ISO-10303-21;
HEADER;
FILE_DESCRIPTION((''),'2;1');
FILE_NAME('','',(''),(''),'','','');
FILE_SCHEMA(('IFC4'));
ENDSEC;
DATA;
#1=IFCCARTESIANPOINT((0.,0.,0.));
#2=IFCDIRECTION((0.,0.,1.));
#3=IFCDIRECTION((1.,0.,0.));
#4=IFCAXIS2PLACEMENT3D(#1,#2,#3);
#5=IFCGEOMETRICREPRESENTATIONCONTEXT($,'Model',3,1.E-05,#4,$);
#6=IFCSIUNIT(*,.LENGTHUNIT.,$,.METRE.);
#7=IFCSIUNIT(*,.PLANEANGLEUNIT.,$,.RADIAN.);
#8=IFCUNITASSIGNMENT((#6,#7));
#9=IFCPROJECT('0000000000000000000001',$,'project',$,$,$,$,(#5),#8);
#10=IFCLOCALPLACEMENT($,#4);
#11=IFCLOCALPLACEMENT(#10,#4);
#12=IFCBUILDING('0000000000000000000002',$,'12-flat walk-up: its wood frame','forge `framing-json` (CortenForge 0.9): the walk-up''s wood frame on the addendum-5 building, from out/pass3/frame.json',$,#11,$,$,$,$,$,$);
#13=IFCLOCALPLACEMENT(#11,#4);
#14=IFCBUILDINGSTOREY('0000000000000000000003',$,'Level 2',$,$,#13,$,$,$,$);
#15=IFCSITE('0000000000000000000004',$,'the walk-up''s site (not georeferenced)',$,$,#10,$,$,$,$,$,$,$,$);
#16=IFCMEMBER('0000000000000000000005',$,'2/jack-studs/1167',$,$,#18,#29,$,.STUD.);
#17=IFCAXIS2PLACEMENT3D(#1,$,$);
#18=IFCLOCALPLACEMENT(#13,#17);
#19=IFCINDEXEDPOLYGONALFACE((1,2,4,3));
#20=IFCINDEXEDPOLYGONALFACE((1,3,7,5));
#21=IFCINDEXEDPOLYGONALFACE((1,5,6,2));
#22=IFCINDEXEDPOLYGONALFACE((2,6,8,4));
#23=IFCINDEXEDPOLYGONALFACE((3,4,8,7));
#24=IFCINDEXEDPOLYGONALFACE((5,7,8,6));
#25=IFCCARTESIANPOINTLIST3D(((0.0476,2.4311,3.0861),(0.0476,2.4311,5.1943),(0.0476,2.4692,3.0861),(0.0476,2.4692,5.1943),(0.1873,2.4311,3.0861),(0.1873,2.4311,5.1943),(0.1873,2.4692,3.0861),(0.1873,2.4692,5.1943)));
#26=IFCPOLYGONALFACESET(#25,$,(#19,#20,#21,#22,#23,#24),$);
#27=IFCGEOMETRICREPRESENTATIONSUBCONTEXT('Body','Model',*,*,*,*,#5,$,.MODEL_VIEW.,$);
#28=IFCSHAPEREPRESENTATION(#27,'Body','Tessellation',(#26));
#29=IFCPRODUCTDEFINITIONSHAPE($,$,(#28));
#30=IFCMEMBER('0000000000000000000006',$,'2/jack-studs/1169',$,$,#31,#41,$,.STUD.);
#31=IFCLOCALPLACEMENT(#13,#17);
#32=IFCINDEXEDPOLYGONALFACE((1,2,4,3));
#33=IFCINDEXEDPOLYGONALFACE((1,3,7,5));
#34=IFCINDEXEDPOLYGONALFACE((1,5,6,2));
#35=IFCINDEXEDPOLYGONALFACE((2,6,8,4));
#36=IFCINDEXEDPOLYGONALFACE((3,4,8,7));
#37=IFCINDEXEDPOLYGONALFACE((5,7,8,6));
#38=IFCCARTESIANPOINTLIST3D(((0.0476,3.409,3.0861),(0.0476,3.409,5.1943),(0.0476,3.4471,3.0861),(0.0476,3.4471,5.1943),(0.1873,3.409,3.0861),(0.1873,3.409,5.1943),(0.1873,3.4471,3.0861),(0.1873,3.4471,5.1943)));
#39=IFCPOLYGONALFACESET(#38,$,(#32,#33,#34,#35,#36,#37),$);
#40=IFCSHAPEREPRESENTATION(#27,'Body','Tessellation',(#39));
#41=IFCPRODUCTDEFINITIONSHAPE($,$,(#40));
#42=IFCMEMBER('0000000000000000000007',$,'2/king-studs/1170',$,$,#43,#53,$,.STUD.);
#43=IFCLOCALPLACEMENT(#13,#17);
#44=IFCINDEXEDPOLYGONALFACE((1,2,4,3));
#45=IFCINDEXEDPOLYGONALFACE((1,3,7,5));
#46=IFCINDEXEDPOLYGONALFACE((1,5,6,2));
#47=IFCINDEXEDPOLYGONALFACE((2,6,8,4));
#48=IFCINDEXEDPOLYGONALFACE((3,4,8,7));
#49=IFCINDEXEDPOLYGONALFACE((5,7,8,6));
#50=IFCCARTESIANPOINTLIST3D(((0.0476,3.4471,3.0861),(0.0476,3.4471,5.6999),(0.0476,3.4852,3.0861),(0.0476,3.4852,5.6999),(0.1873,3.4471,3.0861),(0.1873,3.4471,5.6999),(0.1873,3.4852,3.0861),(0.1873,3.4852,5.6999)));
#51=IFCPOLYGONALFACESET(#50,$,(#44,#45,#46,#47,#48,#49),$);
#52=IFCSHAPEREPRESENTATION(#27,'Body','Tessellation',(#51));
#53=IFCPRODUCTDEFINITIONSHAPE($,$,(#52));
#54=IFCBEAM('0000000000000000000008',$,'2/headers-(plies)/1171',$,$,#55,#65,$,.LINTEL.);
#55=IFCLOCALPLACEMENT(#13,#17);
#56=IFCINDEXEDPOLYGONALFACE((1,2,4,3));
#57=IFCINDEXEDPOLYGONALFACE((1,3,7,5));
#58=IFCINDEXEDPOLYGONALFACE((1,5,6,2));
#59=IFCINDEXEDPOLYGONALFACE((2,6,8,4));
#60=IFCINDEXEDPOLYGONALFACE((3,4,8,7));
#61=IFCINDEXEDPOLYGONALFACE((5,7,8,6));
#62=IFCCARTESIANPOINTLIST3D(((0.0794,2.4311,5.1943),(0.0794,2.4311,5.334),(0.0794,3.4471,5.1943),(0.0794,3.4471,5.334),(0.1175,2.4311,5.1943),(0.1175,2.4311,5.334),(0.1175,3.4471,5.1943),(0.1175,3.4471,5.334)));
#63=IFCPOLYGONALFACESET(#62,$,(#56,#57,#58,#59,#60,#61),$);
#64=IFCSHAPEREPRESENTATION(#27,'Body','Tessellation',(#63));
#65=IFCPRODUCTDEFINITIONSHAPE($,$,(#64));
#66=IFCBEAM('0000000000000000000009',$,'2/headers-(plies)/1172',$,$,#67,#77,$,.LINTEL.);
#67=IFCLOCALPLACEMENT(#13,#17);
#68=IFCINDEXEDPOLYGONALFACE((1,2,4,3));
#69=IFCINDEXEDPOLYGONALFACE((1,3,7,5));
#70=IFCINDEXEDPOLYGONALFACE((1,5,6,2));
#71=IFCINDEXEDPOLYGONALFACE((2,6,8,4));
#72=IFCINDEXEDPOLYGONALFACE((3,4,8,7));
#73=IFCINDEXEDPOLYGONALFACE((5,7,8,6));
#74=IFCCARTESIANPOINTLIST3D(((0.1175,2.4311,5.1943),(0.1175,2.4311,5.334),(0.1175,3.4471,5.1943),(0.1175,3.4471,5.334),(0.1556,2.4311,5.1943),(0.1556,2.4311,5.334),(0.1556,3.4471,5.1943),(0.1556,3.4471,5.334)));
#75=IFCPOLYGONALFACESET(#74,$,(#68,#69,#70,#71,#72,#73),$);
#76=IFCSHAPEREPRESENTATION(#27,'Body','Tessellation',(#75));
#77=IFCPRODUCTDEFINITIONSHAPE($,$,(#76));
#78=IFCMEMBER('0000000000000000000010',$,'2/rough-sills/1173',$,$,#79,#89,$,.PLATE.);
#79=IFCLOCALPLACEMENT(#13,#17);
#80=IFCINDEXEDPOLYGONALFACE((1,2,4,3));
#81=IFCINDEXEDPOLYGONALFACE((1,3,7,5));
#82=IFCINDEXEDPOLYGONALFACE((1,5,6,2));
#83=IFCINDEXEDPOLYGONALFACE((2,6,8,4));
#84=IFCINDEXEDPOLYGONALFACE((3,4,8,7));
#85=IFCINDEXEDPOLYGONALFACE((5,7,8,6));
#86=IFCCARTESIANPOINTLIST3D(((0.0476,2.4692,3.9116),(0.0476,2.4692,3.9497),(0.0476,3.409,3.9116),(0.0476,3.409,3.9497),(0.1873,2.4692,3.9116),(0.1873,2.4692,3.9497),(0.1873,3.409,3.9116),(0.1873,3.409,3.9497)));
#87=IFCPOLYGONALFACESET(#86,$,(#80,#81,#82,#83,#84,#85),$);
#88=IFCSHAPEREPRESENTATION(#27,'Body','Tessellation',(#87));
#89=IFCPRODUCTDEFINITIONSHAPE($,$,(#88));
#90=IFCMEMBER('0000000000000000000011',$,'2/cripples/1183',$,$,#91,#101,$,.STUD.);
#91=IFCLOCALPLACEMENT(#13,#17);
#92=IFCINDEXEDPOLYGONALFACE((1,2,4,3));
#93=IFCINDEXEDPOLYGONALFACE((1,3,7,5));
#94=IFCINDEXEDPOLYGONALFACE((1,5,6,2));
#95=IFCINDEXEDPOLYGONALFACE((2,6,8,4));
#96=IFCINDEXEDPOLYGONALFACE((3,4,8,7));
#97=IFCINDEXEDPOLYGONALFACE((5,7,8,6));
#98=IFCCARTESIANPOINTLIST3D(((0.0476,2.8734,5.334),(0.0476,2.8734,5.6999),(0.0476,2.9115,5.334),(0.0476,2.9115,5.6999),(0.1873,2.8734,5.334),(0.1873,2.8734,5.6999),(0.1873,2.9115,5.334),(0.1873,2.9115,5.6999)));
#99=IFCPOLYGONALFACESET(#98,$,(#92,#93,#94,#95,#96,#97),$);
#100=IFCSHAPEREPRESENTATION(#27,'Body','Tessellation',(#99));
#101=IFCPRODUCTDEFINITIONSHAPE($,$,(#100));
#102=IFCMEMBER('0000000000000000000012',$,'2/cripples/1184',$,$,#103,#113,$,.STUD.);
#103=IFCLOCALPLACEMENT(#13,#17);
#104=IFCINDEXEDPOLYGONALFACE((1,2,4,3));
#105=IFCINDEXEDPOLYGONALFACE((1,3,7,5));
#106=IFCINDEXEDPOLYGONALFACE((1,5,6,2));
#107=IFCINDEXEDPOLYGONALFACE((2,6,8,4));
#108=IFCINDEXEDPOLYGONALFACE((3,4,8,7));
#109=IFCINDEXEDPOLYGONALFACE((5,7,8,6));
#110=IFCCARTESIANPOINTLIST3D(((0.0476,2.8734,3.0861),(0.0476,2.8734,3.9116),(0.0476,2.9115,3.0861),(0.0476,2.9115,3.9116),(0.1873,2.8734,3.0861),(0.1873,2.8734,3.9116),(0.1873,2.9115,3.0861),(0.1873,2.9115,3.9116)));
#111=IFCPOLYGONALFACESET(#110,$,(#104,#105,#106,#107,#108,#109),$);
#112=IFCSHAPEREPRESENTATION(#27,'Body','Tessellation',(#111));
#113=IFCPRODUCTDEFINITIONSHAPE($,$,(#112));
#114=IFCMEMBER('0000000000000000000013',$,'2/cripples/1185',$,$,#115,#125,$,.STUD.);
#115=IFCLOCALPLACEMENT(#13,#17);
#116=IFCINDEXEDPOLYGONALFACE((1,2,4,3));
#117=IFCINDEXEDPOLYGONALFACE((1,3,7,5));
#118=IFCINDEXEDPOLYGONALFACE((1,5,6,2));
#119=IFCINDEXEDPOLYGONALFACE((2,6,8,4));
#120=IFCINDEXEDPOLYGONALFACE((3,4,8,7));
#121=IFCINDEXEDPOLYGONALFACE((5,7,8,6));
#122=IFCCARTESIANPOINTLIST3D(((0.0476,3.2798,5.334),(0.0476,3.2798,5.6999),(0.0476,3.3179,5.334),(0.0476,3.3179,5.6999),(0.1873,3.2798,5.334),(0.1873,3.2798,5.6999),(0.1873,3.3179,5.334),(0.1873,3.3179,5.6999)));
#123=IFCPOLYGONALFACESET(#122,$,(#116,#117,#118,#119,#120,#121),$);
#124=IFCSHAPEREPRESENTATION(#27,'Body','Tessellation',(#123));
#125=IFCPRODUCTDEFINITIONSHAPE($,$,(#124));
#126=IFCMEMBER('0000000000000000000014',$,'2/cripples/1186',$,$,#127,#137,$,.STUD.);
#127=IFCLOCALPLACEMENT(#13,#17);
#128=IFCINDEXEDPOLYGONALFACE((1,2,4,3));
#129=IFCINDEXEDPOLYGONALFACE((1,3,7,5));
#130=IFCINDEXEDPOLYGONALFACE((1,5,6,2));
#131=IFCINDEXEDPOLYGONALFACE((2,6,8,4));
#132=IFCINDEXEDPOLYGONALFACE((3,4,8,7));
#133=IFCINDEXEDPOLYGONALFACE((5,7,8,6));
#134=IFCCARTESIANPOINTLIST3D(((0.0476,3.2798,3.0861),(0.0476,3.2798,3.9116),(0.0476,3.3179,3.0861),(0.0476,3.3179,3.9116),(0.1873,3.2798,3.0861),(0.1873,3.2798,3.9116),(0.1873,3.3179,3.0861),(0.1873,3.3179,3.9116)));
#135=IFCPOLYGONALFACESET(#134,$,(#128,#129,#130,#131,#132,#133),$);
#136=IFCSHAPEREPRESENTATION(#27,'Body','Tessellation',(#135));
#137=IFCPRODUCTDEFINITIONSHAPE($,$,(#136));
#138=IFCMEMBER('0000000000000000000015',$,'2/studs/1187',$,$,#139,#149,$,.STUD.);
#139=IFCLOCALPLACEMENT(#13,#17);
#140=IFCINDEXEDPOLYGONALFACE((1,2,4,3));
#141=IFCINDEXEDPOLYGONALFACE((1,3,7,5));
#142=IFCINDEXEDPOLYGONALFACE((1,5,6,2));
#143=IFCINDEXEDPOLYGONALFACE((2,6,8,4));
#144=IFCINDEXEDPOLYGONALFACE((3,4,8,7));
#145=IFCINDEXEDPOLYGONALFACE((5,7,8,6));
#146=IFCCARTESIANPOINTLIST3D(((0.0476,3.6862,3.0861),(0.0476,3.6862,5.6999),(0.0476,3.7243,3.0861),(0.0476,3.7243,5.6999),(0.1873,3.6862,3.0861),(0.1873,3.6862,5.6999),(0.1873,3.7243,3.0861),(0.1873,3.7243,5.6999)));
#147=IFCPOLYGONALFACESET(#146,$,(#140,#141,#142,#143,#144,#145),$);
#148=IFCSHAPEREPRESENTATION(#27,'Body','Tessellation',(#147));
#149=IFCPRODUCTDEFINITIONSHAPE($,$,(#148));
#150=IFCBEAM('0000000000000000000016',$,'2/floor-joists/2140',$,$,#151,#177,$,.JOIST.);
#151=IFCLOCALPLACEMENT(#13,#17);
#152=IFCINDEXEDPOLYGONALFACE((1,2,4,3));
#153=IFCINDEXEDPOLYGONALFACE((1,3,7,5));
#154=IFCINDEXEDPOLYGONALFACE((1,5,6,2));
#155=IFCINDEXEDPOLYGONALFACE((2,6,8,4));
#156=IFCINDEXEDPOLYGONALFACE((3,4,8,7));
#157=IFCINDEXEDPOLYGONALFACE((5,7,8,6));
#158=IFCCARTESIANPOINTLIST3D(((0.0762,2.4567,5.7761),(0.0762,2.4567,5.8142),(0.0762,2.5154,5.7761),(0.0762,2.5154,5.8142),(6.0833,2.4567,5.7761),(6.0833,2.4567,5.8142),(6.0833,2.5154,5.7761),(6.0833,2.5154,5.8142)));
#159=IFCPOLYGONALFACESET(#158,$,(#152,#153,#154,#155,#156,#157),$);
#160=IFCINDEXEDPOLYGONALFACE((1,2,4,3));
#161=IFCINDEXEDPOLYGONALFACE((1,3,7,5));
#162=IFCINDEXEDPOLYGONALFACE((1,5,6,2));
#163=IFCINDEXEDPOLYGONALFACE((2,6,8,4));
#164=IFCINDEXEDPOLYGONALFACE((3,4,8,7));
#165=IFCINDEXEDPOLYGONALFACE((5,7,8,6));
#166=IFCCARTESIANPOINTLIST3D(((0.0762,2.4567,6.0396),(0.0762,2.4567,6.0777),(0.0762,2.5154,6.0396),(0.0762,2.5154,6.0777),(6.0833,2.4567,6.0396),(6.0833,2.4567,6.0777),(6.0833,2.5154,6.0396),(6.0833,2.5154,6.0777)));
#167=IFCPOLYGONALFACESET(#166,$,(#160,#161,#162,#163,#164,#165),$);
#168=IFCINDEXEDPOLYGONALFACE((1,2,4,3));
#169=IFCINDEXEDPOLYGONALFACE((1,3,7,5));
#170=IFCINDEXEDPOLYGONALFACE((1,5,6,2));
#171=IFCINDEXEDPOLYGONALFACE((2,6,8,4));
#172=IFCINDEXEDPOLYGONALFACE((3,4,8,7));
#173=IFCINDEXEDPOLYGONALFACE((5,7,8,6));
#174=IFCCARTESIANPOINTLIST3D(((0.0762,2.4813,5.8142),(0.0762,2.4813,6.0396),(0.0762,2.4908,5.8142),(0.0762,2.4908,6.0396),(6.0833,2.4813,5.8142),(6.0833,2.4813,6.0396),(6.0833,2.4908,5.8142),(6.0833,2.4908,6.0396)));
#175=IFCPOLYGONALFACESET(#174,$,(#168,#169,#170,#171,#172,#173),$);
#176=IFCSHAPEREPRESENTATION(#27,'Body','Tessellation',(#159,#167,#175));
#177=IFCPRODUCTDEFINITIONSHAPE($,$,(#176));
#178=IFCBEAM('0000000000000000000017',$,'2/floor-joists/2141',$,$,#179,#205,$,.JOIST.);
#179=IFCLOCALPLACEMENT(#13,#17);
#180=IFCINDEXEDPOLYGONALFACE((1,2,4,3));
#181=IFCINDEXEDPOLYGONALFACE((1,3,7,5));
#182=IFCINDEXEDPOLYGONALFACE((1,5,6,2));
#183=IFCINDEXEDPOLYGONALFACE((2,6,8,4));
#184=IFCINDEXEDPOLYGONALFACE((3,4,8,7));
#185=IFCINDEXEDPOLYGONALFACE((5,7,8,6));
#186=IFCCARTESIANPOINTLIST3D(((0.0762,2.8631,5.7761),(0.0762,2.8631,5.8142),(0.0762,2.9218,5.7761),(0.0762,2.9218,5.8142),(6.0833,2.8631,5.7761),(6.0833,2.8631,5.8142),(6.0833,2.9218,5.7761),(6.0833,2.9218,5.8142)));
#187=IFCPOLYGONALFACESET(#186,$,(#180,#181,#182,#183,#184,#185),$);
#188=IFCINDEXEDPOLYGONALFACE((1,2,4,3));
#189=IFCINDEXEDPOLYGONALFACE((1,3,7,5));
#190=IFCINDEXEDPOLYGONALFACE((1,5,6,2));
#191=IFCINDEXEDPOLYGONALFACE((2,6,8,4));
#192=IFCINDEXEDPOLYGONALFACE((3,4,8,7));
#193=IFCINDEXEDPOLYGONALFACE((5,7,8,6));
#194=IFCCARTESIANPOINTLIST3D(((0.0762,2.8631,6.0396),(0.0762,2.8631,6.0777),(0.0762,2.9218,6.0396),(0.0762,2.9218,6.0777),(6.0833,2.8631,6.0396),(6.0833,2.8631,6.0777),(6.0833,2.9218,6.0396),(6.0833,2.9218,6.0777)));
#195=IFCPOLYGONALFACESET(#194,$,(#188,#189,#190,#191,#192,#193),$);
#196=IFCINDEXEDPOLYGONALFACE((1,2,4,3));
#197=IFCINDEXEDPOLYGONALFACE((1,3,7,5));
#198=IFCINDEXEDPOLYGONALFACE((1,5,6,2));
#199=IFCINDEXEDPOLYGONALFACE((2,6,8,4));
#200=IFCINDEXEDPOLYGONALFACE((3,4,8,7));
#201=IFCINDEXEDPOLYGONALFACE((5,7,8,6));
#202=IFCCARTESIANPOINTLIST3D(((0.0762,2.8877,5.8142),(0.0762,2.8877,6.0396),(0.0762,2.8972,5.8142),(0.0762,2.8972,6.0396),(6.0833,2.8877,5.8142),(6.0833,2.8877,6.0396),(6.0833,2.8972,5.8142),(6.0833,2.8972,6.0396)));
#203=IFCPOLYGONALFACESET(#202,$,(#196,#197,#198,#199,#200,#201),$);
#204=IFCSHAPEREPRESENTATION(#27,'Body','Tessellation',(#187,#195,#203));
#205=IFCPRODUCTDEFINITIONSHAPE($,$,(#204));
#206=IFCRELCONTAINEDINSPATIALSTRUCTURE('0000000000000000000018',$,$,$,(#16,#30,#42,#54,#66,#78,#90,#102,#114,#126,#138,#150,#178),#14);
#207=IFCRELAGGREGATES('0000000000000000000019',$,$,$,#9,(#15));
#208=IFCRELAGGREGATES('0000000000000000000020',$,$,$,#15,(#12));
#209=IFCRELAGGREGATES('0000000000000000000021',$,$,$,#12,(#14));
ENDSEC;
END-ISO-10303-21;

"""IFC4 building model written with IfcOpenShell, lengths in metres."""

from ifc_helpers import new_model, si_unit, frame, frame_2d, origin, origin_with_axes, place, context, subcontext, project, spatial, rectangle, extrude, element, save


model = new_model("IFC4")

# Units and contexts
model_context = context("Model", 3, precision=1e-05, world=origin_with_axes())
body_context = subcontext(model_context, "Body", "Model", "MODEL_VIEW")
ifc_project = project(units=[si_unit("LENGTHUNIT", "METRE"), si_unit("PLANEANGLEUNIT", "RADIAN")], contexts=[model_context])

# Site, building, storey
site_placement = place(None, origin_with_axes())
site = spatial("IfcSite", under=ifc_project, at=site_placement, Name="the walk-up's site (not georeferenced)")
building_placement = place(site_placement, origin_with_axes())
building = spatial("IfcBuilding", under=site, at=building_placement, Name="12-flat walk-up: its wood frame", Description="forge `framing-json` (CortenForge 0.9): the walk-up's wood frame on the addendum-5 building, from out/pass3/frame.json")
storey_placement = place(building_placement, origin_with_axes())
storey = spatial("IfcBuildingStorey", under=building, at=storey_placement, Name="Level 2")

# Members
for number, where, z_axis, x_axis, name in (
    (1, (0.0476, 2.4311, 3.0861), (0.0, 0.0, 1.0), (1.0, 0.0, 0.0), "2/jack-studs/1167"),
    (2, (0.0476, 3.409, 3.0861), (0.0, 0.0, 1.0), (1.0, 0.0, 0.0), "2/jack-studs/1169"),
):
    element("IfcMember", number, at=place(storey_placement, frame(where, z_axis=z_axis, x_axis=x_axis)), inside=storey, Name=name, PredefinedType="STUD", context=body_context, shape_type="SweptSolid", body=[
        extrude(rectangle(XDim=0.1397, YDim=0.0381, at=frame_2d((0.0698, 0.0191))), origin(), (0.0, 0.0, 1.0), 2.1082),
    ])
member_1_placement = place(storey_placement, frame((0.0476, 3.4471, 3.0861), z_axis=(0.0, 0.0, 1.0), x_axis=(1.0, 0.0, 0.0)))
element("IfcMember", 3, at=member_1_placement, inside=storey, Name="2/king-studs/1170", PredefinedType="STUD", context=body_context, shape_type="SweptSolid", body=[
    extrude(rectangle(XDim=0.1397, YDim=0.0381, at=frame_2d((0.0698, 0.0191))), origin(), (0.0, 0.0, 1.0), 2.6138),
])

# Beams
for number, where, z_axis, x_axis, name in (
    (4, (0.0794, 2.4311, 5.1943), (0.0, 0.0, 1.0), (1.0, 0.0, 0.0), "2/headers-(plies)/1171"),
    (5, (0.1175, 2.4311, 5.1943), (0.0, 0.0, 1.0), (1.0, 0.0, 0.0), "2/headers-(plies)/1172"),
):
    element("IfcBeam", number, at=place(storey_placement, frame(where, z_axis=z_axis, x_axis=x_axis)), inside=storey, Name=name, PredefinedType="LINTEL", context=body_context, shape_type="SweptSolid", body=[
        extrude(rectangle(XDim=0.0381, YDim=1.016, at=frame_2d((0.019, 0.508))), origin(), (0.0, 0.0, 1.0), 0.1397),
    ])

# Members
member_2_placement = place(storey_placement, frame((0.0476, 2.4692, 3.9116), z_axis=(0.0, 0.0, 1.0), x_axis=(1.0, 0.0, 0.0)))
element("IfcMember", 6, at=member_2_placement, inside=storey, Name="2/rough-sills/1173", PredefinedType="PLATE", context=body_context, shape_type="SweptSolid", body=[
    extrude(rectangle(XDim=0.1397, YDim=0.9398, at=frame_2d((0.0698, 0.4699))), origin(), (0.0, 0.0, 1.0), 0.0381),
])
member_3_placement = place(storey_placement, frame((0.0476, 2.8734, 5.334), z_axis=(0.0, 0.0, 1.0), x_axis=(1.0, 0.0, 0.0)))
element("IfcMember", 7, at=member_3_placement, inside=storey, Name="2/cripples/1183", PredefinedType="STUD", context=body_context, shape_type="SweptSolid", body=[
    extrude(rectangle(XDim=0.1397, YDim=0.0381, at=frame_2d((0.0698, 0.0191))), origin(), (0.0, 0.0, 1.0), 0.3659),
])
member_4_placement = place(storey_placement, frame((0.0476, 2.8734, 3.0861), z_axis=(0.0, 0.0, 1.0), x_axis=(1.0, 0.0, 0.0)))
element("IfcMember", 8, at=member_4_placement, inside=storey, Name="2/cripples/1184", PredefinedType="STUD", context=body_context, shape_type="SweptSolid", body=[
    extrude(rectangle(XDim=0.1397, YDim=0.0381, at=frame_2d((0.0698, 0.0191))), origin(), (0.0, 0.0, 1.0), 0.8255),
])
member_5_placement = place(storey_placement, frame((0.0476, 3.2798, 5.334), z_axis=(0.0, 0.0, 1.0), x_axis=(1.0, 0.0, 0.0)))
element("IfcMember", 9, at=member_5_placement, inside=storey, Name="2/cripples/1185", PredefinedType="STUD", context=body_context, shape_type="SweptSolid", body=[
    extrude(rectangle(XDim=0.1397, YDim=0.0381, at=frame_2d((0.0698, 0.0191))), origin(), (0.0, 0.0, 1.0), 0.3659),
])
member_6_placement = place(storey_placement, frame((0.0476, 3.2798, 3.0861), z_axis=(0.0, 0.0, 1.0), x_axis=(1.0, 0.0, 0.0)))
element("IfcMember", 10, at=member_6_placement, inside=storey, Name="2/cripples/1186", PredefinedType="STUD", context=body_context, shape_type="SweptSolid", body=[
    extrude(rectangle(XDim=0.1397, YDim=0.0381, at=frame_2d((0.0698, 0.0191))), origin(), (0.0, 0.0, 1.0), 0.8255),
])
member_7_placement = place(storey_placement, frame((0.0476, 3.6862, 3.0861), z_axis=(0.0, 0.0, 1.0), x_axis=(1.0, 0.0, 0.0)))
element("IfcMember", 11, at=member_7_placement, inside=storey, Name="2/studs/1187", PredefinedType="STUD", context=body_context, shape_type="SweptSolid", body=[
    extrude(rectangle(XDim=0.1397, YDim=0.0381, at=frame_2d((0.0698, 0.0191))), origin(), (0.0, 0.0, 1.0), 2.6138),
])

# Beams
beam_placement = place(storey_placement, frame((0.0762, 2.4567, 5.7761), z_axis=(0.0, 0.0, 1.0), x_axis=(1.0, 0.0, 0.0)))
element("IfcBeam", 12, at=beam_placement, inside=storey, Name="2/floor-joists/2140", PredefinedType="JOIST", context=body_context, shape_type="SweptSolid", body=[
    extrude(rectangle(XDim=6.0071, YDim=0.0587, at=frame_2d((3.0036, 0.0294))), origin(), (0.0, 0.0, 1.0), 0.0381),
    extrude(rectangle(XDim=6.0071, YDim=0.0587, at=frame_2d((3.0036, 0.0294))), frame((0.0, 0.0, 0.2635)), (0.0, 0.0, 1.0), 0.0381),
    extrude(rectangle(XDim=6.0071, YDim=0.0095, at=frame_2d((3.0036, 0.0048))), frame((0.0, 0.0246, 0.0381)), (0.0, 0.0, 1.0), 0.2254),
])
for number, where, z_axis, x_axis, name in (
    (13, (0.0762, 2.8631, 5.7761), (0.0, 0.0, 1.0), (1.0, 0.0, 0.0), "2/floor-joists/2141"),
):
    element("IfcBeam", number, at=place(storey_placement, frame(where, z_axis=z_axis, x_axis=x_axis)), inside=storey, Name=name, PredefinedType="JOIST", context=body_context, shape_type="SweptSolid", body=[
        extrude(rectangle(XDim=6.0071, YDim=0.0587, at=frame_2d((3.0036, 0.0294))), origin(), (0.0, 0.0, 1.0), 0.0381),
        extrude(rectangle(XDim=6.0071, YDim=0.0587, at=frame_2d((3.0036, 0.0294))), frame((0.0, 0.0, 0.2635)), (0.0, 0.0, 1.0), 0.0381),
        extrude(rectangle(XDim=6.0071, YDim=0.0095, at=frame_2d((3.0036, 0.0048))), frame((0.0, 0.0246, 0.0381)), (0.0, 0.0, 1.0), 0.2254),
    ])

save(model, "model.ifc")
